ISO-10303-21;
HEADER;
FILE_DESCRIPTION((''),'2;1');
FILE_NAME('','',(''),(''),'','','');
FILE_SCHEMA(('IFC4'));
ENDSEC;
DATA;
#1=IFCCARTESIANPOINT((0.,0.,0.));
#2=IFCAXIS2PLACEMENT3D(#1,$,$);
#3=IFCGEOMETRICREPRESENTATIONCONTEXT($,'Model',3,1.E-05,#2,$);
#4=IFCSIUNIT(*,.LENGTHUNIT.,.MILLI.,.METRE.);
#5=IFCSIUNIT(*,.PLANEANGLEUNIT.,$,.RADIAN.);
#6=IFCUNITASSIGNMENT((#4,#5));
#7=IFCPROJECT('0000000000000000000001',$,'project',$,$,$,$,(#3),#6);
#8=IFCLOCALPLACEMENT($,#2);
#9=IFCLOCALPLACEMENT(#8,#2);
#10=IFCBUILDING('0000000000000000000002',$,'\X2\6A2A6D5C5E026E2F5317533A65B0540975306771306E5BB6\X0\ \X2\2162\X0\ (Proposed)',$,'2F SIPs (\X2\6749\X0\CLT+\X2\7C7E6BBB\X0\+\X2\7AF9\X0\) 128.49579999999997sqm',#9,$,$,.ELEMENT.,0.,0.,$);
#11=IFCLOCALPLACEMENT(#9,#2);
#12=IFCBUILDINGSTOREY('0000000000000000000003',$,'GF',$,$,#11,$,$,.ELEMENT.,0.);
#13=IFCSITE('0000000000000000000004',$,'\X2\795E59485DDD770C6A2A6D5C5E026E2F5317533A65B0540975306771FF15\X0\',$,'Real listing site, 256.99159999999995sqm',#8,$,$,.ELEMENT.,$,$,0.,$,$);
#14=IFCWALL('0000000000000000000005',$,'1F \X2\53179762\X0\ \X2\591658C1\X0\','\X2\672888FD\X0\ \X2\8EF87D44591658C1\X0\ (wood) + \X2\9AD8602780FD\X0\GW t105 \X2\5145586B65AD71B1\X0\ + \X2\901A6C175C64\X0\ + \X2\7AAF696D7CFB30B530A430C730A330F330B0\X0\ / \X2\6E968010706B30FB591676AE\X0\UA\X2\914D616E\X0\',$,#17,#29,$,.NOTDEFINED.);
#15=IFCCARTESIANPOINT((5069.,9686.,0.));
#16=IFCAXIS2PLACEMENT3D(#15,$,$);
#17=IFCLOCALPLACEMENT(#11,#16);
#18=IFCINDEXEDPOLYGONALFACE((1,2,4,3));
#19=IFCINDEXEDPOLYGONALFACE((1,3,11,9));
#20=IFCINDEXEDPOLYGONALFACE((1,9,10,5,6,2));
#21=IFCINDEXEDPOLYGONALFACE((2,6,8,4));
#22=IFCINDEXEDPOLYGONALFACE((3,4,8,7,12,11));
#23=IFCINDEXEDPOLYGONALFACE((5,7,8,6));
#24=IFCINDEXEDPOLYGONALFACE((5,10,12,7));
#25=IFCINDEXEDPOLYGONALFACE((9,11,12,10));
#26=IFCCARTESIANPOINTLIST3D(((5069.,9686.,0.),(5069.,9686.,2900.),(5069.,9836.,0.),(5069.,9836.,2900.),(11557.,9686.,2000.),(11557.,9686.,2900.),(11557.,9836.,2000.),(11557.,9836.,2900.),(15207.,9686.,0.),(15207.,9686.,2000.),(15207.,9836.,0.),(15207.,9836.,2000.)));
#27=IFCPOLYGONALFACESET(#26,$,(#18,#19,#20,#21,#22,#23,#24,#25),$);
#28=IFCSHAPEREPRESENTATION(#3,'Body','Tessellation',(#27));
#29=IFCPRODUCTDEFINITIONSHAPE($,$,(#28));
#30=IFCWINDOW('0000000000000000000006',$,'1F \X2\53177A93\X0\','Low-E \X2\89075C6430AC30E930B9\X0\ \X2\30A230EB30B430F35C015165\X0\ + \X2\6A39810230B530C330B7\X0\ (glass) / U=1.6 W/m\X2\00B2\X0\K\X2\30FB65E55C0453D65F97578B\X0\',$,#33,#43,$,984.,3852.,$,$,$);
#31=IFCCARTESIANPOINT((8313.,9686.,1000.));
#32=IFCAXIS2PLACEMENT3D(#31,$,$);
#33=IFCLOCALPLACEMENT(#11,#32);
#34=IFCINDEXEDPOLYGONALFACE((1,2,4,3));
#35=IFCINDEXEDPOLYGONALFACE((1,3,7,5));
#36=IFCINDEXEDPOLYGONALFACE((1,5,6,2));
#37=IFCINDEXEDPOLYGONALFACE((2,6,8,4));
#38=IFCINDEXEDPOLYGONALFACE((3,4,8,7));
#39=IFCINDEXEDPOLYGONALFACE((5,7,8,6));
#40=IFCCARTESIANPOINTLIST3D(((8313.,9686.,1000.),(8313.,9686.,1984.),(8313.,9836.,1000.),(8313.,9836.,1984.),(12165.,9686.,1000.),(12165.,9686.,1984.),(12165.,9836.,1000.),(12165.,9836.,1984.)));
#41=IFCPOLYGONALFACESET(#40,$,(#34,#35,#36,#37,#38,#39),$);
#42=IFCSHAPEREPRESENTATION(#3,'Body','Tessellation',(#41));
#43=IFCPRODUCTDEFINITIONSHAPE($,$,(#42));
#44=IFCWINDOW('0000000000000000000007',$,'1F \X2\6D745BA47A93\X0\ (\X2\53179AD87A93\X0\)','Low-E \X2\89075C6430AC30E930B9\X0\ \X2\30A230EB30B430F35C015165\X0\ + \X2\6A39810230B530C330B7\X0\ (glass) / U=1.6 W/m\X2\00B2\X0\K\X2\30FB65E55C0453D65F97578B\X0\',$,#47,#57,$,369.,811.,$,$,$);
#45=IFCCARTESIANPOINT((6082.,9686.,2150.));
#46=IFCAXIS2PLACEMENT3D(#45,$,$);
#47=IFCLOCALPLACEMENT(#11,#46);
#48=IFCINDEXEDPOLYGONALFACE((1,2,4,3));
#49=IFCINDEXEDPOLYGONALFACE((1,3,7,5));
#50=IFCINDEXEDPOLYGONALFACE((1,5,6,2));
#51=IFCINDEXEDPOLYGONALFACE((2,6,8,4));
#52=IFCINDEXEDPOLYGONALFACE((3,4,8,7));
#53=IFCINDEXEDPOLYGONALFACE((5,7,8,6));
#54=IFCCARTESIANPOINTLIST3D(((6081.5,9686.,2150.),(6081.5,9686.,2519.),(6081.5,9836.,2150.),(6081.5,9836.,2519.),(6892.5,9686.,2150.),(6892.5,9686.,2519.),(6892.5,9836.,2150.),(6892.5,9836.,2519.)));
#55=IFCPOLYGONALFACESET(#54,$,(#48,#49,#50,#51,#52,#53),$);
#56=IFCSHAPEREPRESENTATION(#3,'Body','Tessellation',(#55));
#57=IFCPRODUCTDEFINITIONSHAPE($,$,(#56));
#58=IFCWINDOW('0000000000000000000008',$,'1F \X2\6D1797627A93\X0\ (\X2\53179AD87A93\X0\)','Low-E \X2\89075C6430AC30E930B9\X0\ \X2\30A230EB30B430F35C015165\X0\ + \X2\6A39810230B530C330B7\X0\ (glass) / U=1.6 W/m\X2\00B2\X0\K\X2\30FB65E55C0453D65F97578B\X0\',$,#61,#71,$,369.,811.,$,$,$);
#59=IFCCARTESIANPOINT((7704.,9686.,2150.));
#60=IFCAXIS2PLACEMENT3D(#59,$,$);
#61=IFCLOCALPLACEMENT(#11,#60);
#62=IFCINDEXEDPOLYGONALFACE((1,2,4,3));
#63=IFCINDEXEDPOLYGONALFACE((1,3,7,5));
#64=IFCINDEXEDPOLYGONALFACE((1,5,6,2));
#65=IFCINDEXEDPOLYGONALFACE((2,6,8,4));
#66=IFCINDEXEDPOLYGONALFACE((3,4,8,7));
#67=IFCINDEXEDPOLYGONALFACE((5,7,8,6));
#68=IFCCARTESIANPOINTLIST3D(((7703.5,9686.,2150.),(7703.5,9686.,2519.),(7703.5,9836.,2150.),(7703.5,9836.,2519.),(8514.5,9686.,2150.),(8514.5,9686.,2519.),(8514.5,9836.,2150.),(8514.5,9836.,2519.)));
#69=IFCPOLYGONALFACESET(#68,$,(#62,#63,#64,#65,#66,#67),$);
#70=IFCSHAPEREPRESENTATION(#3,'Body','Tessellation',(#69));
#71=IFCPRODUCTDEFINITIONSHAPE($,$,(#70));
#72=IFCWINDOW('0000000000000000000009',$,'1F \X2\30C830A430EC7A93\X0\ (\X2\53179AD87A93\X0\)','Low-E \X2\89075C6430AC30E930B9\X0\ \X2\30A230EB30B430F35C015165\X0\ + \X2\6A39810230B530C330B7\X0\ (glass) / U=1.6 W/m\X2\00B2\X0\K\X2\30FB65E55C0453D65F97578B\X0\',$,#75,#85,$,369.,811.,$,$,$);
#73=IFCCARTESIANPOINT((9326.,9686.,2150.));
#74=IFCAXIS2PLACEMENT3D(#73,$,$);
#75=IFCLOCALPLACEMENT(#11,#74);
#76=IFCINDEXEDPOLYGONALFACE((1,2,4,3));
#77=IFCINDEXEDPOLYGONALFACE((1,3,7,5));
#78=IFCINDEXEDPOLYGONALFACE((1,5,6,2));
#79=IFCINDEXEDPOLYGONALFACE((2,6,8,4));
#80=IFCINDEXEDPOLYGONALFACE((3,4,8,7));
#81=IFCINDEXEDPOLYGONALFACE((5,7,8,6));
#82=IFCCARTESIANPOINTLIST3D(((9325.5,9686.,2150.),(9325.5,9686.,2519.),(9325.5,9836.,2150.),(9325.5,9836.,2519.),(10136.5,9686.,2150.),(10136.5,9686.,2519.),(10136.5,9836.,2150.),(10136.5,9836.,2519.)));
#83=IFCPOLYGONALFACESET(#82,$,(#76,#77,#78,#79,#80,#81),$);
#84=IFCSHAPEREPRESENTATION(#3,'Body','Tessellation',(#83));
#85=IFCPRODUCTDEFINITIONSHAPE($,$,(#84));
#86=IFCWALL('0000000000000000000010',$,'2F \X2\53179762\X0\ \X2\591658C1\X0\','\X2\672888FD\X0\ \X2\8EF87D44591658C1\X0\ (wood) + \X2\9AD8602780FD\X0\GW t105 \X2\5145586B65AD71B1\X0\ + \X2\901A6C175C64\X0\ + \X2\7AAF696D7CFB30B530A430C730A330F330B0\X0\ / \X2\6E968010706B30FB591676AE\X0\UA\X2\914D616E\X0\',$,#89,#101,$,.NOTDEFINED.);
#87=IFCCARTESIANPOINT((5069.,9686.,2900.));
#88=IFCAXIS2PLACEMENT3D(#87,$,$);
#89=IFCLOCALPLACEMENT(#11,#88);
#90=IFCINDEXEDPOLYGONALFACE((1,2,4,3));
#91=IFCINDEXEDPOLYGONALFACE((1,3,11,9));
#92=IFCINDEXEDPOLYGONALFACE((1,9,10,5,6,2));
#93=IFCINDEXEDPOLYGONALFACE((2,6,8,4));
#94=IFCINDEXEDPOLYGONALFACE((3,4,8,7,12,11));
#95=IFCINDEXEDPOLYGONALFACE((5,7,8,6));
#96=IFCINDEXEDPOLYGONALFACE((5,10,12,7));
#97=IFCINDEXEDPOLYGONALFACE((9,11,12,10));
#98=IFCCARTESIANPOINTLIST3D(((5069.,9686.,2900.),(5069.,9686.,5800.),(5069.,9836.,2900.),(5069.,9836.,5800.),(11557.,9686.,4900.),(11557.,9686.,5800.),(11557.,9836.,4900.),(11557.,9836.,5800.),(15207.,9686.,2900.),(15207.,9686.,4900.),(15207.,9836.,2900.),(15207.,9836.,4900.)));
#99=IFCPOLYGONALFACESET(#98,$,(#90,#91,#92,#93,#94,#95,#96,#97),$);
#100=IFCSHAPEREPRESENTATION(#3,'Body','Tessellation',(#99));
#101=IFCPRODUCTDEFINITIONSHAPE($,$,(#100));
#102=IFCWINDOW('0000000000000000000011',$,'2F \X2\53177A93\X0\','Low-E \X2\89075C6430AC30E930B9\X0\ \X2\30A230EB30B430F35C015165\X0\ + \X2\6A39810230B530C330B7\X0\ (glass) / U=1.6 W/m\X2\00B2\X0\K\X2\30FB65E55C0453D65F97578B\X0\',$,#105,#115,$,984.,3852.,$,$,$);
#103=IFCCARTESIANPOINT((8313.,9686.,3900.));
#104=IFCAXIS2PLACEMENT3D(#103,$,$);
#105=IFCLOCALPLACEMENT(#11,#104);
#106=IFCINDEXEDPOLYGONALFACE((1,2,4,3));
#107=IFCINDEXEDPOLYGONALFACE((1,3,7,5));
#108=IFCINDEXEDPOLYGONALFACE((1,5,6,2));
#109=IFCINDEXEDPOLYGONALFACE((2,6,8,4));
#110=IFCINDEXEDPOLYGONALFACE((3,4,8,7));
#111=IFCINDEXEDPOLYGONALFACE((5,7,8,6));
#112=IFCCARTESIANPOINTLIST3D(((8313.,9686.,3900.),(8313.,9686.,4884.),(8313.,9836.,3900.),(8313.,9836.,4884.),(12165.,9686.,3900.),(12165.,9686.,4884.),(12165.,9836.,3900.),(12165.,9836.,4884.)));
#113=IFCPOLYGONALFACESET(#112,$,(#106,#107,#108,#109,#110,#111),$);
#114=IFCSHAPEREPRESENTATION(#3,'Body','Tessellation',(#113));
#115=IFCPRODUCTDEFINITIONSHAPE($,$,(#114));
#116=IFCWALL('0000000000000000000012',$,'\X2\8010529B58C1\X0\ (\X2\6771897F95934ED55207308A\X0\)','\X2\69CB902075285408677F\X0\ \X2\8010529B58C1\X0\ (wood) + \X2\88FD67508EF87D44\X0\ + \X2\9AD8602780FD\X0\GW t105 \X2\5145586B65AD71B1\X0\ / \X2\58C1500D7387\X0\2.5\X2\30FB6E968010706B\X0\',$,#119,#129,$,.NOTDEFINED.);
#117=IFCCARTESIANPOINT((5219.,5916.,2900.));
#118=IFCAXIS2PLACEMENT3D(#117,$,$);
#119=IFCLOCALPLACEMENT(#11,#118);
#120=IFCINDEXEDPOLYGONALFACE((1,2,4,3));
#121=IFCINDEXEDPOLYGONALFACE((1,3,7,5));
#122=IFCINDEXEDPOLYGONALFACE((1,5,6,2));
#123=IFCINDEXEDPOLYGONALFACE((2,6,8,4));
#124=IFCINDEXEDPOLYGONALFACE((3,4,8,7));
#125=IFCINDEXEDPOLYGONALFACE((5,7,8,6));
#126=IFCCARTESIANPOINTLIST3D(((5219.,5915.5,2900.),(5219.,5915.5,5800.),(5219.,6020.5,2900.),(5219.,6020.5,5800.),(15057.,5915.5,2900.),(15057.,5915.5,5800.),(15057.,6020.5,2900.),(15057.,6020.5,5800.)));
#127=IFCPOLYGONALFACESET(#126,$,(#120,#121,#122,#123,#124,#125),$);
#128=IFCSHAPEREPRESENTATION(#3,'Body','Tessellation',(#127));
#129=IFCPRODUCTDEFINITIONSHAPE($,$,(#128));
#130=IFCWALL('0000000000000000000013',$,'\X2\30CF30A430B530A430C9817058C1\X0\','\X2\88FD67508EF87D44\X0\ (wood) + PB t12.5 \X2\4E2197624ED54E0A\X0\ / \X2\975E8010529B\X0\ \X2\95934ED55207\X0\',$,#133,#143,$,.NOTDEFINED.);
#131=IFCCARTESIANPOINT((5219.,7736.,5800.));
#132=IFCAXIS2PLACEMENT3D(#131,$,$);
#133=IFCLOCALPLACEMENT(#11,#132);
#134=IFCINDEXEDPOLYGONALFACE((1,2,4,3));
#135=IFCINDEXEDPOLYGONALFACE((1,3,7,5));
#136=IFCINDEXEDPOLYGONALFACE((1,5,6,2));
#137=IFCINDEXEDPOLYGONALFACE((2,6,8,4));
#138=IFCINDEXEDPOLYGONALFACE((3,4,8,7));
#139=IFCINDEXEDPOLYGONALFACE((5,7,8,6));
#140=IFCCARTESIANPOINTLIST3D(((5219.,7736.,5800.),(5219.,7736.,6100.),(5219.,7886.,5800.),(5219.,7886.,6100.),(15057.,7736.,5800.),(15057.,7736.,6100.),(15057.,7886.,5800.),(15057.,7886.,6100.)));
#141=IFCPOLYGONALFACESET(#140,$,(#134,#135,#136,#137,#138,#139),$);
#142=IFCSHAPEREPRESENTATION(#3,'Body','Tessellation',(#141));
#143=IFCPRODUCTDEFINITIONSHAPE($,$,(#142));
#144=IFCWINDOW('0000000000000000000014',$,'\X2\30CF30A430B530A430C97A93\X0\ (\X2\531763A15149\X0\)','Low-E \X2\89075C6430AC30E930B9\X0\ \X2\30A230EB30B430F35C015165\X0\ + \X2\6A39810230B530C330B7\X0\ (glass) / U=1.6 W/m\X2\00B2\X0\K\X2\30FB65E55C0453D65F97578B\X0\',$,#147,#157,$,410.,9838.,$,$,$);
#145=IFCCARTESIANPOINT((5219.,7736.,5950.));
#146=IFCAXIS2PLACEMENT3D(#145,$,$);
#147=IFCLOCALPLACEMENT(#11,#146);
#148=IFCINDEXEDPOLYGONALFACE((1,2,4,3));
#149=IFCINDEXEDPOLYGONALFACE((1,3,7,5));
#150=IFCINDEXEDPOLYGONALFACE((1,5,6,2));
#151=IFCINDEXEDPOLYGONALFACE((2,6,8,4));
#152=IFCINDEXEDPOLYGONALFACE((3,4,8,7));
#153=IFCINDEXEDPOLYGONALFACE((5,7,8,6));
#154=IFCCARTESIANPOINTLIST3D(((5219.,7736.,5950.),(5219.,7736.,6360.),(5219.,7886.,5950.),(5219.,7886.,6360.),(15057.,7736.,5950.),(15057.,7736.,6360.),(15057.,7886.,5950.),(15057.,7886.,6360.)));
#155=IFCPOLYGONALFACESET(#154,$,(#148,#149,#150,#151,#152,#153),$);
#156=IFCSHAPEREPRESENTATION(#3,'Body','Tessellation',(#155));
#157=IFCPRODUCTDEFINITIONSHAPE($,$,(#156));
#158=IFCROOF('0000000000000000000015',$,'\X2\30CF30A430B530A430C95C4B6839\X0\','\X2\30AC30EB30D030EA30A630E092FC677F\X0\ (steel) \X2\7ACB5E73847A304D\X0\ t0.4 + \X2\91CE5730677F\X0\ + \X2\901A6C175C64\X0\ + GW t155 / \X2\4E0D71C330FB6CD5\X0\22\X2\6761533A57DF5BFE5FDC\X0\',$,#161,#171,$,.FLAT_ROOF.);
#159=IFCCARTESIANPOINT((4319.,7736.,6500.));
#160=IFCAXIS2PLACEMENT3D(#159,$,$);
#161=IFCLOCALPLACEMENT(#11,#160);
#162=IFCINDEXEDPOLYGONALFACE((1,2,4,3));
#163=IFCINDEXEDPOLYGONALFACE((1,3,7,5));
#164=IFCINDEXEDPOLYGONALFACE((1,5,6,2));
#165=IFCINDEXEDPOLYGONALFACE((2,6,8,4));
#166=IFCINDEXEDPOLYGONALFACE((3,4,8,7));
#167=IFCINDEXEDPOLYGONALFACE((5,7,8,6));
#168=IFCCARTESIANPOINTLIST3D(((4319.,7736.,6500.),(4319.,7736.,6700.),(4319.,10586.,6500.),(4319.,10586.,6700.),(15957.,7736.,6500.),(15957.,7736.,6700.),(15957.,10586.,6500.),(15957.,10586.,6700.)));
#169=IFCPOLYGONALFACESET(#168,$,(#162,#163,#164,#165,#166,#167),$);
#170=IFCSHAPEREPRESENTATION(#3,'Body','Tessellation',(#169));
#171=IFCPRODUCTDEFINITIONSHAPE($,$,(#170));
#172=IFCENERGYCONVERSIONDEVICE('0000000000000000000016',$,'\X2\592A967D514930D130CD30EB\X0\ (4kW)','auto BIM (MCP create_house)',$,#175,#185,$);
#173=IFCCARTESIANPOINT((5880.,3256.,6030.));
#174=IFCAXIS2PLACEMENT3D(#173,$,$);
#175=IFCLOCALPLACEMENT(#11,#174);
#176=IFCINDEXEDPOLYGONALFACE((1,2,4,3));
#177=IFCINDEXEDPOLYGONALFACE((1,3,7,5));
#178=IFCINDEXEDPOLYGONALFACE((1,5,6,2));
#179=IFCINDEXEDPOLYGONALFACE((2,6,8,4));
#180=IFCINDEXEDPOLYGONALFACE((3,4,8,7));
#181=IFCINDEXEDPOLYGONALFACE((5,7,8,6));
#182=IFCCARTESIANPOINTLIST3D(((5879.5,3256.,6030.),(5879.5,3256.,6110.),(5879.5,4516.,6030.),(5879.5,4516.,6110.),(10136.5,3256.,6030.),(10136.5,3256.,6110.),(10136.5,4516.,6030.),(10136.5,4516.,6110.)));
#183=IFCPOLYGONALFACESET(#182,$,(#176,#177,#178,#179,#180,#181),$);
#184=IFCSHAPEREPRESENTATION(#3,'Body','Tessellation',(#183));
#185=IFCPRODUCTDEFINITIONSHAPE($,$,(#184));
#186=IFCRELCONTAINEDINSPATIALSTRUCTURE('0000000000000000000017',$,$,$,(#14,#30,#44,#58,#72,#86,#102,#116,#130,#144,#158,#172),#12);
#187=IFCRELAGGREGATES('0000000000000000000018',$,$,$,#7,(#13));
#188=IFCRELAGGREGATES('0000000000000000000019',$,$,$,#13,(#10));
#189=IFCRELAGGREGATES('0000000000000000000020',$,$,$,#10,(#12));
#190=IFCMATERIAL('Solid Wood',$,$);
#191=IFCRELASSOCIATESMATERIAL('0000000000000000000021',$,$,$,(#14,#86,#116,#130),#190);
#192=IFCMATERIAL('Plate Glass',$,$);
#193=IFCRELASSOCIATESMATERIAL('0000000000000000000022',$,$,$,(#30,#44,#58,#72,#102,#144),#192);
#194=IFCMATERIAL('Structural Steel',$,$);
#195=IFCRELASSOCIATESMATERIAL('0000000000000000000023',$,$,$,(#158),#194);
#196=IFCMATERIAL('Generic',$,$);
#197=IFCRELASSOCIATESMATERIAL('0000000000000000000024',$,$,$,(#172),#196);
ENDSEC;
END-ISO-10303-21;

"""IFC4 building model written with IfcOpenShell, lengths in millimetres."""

from ifc_helpers import new_model, si_unit, frame, frame_2d, origin, place, context, project, spatial, rectangle, extrude, material, element, fill, save


model = new_model("IFC4")

# Units and contexts
model_context = context("Model", 3, precision=1e-05, world=origin())
ifc_project = project(units=[si_unit("LENGTHUNIT", "METRE", prefix="MILLI"), si_unit("PLANEANGLEUNIT", "RADIAN")], contexts=[model_context])

# Site, building, storey
site_placement = place(None, origin())
site = spatial("IfcSite", under=ifc_project, at=site_placement, Name="神奈川県横浜市港北区新吉田東５", ObjectType="Real listing site, 256.99159999999995sqm", CompositionType="ELEMENT", RefElevation=0.0)
building_placement = place(site_placement, origin())
building = spatial("IfcBuilding", under=site, at=building_placement, Name="横浜市港北区新吉田東の家 Ⅲ (Proposed)", ObjectType="2F SIPs (杉CLT+籾殻+竹) 128.49579999999997sqm", CompositionType="ELEMENT", ElevationOfRefHeight=0.0, ElevationOfTerrain=0.0)
storey_placement = place(building_placement, origin())
storey = spatial("IfcBuildingStorey", under=building, at=storey_placement, Name="GF", CompositionType="ELEMENT", Elevation=0.0)

# Wall, openings, windows
ifc_material_1 = material(Name="Solid Wood")
wall_1_placement = place(storey_placement, frame((5069.0, 9686.0, 0.0)))
wall_1 = element("IfcWall", 1, at=wall_1_placement, inside=storey, material=ifc_material_1, Name="1F 北面 外壁", Description="木製 軸組外壁 (wood) + 高性能GW t105 充填断熱 + 通気層 + 窯業系サイディング / 準耐火・外皮UA配慮", PredefinedType="NOTDEFINED", context=model_context, shape_type="SweptSolid", body=[
    extrude(rectangle(XDim=10138.0, YDim=150.0, at=frame_2d((5069.0, 75.0))), frame((5069.0, 9686.0, 0.0)), (0.0, 0.0, 1.0), 2900.0),
])
opening_1_placement = place(storey_placement, frame((8313.0, 9686.0, 1000.0)))
opening_1 = element("IfcOpeningElement", 2, at=opening_1_placement, cuts=wall_1, PredefinedType="NOTDEFINED", context=model_context, shape_type="SweptSolid", body=[
    extrude(rectangle(XDim=3852.0, YDim=150.0, at=frame_2d((1926.0, 75.0))), frame((8313.0, 9686.0, 1000.0)), (0.0, 0.0, 1.0), 984.0),
])
opening_2_placement = place(storey_placement, frame((6082.0, 9686.0, 2150.0)))
opening_2 = element("IfcOpeningElement", 3, at=opening_2_placement, cuts=wall_1, PredefinedType="NOTDEFINED", context=model_context, shape_type="SweptSolid", body=[
    extrude(rectangle(XDim=811.0, YDim=150.0, at=frame_2d((405.0, 75.0))), frame((6082.0, 9686.0, 2150.0)), (0.0, 0.0, 1.0), 369.0),
])
opening_3_placement = place(storey_placement, frame((7704.0, 9686.0, 2150.0)))
opening_3 = element("IfcOpeningElement", 4, at=opening_3_placement, cuts=wall_1, PredefinedType="NOTDEFINED", context=model_context, shape_type="SweptSolid", body=[
    extrude(rectangle(XDim=811.0, YDim=150.0, at=frame_2d((405.0, 75.0))), frame((7704.0, 9686.0, 2150.0)), (0.0, 0.0, 1.0), 369.0),
])
opening_4_placement = place(storey_placement, frame((9326.0, 9686.0, 2150.0)))
opening_4 = element("IfcOpeningElement", 5, at=opening_4_placement, cuts=wall_1, PredefinedType="NOTDEFINED", context=model_context, shape_type="SweptSolid", body=[
    extrude(rectangle(XDim=811.0, YDim=150.0, at=frame_2d((405.0, 75.0))), frame((9326.0, 9686.0, 2150.0)), (0.0, 0.0, 1.0), 369.0),
])
ifc_material_2 = material(Name="Plate Glass")
window_1_placement = place(storey_placement, frame((8313.0, 9686.0, 1000.0)))
window_1 = element("IfcWindow", 6, at=window_1_placement, inside=storey, material=ifc_material_2, Name="1F 北窓", Description="Low-E 複層ガラス アルゴン封入 + 樹脂サッシ (glass) / U=1.6 W/m²K・日射取得型", OverallHeight=984.0, OverallWidth=3852.0, context=model_context, shape_type="SweptSolid", body=[
    extrude(rectangle(XDim=3852.0, YDim=150.0, at=frame_2d((1926.0, 75.0))), frame((8313.0, 9686.0, 1000.0)), (0.0, 0.0, 1.0), 984.0),
])
fill(opening_1, window_1)
window_2_placement = place(storey_placement, frame((6082.0, 9686.0, 2150.0)))
window_2 = element("IfcWindow", 7, at=window_2_placement, inside=storey, material=ifc_material_2, Name="1F 浴室窓 (北高窓)", Description="Low-E 複層ガラス アルゴン封入 + 樹脂サッシ (glass) / U=1.6 W/m²K・日射取得型", OverallHeight=369.0, OverallWidth=811.0, context=model_context, shape_type="SweptSolid", body=[
    extrude(rectangle(XDim=811.0, YDim=150.0, at=frame_2d((405.0, 75.0))), frame((6082.0, 9686.0, 2150.0)), (0.0, 0.0, 1.0), 369.0),
])
fill(opening_2, window_2)
window_3_placement = place(storey_placement, frame((7704.0, 9686.0, 2150.0)))
window_3 = element("IfcWindow", 8, at=window_3_placement, inside=storey, material=ifc_material_2, Name="1F 洗面窓 (北高窓)", Description="Low-E 複層ガラス アルゴン封入 + 樹脂サッシ (glass) / U=1.6 W/m²K・日射取得型", OverallHeight=369.0, OverallWidth=811.0, context=model_context, shape_type="SweptSolid", body=[
    extrude(rectangle(XDim=811.0, YDim=150.0, at=frame_2d((405.0, 75.0))), frame((7704.0, 9686.0, 2150.0)), (0.0, 0.0, 1.0), 369.0),
])
fill(opening_3, window_3)
window_4_placement = place(storey_placement, frame((9326.0, 9686.0, 2150.0)))
window_4 = element("IfcWindow", 9, at=window_4_placement, inside=storey, material=ifc_material_2, Name="1F トイレ窓 (北高窓)", Description="Low-E 複層ガラス アルゴン封入 + 樹脂サッシ (glass) / U=1.6 W/m²K・日射取得型", OverallHeight=369.0, OverallWidth=811.0, context=model_context, shape_type="SweptSolid", body=[
    extrude(rectangle(XDim=811.0, YDim=150.0, at=frame_2d((405.0, 75.0))), frame((9326.0, 9686.0, 2150.0)), (0.0, 0.0, 1.0), 369.0),
])
fill(opening_4, window_4)

# Wall, opening, window
wall_2_placement = place(storey_placement, frame((5069.0, 9686.0, 2900.0)))
wall_2 = element("IfcWall", 10, at=wall_2_placement, inside=storey, material=ifc_material_1, Name="2F 北面 外壁", Description="木製 軸組外壁 (wood) + 高性能GW t105 充填断熱 + 通気層 + 窯業系サイディング / 準耐火・外皮UA配慮", PredefinedType="NOTDEFINED", context=model_context, shape_type="SweptSolid", body=[
    extrude(rectangle(XDim=10138.0, YDim=150.0, at=frame_2d((5069.0, 75.0))), frame((5069.0, 9686.0, 2900.0)), (0.0, 0.0, 1.0), 2900.0),
])
opening_5_placement = place(storey_placement, frame((8313.0, 9686.0, 3900.0)))
opening_5 = element("IfcOpeningElement", 11, at=opening_5_placement, cuts=wall_2, PredefinedType="NOTDEFINED", context=model_context, shape_type="SweptSolid", body=[
    extrude(rectangle(XDim=3852.0, YDim=150.0, at=frame_2d((1926.0, 75.0))), frame((8313.0, 9686.0, 3900.0)), (0.0, 0.0, 1.0), 984.0),
])
window_5_placement = place(storey_placement, frame((8313.0, 9686.0, 3900.0)))
window_5 = element("IfcWindow", 12, at=window_5_placement, inside=storey, material=ifc_material_2, Name="2F 北窓", Description="Low-E 複層ガラス アルゴン封入 + 樹脂サッシ (glass) / U=1.6 W/m²K・日射取得型", OverallHeight=984.0, OverallWidth=3852.0, context=model_context, shape_type="SweptSolid", body=[
    extrude(rectangle(XDim=3852.0, YDim=150.0, at=frame_2d((1926.0, 75.0))), frame((8313.0, 9686.0, 3900.0)), (0.0, 0.0, 1.0), 984.0),
])
fill(opening_5, window_5)

# Wall
wall_3_placement = place(storey_placement, frame((5219.0, 5916.0, 2900.0)))
element("IfcWall", 13, at=wall_3_placement, inside=storey, material=ifc_material_1, Name="耐力壁 (東西間仕切り)", Description="構造用合板 耐力壁 (wood) + 製材軸組 + 高性能GW t105 充填断熱 / 壁倍率2.5・準耐火", PredefinedType="NOTDEFINED", context=model_context, shape_type="SweptSolid", body=[
    extrude(rectangle(XDim=9838.0, YDim=105.0, at=frame_2d((4919.0, 52.0))), frame((5219.0, 5916.0, 2900.0)), (0.0, 0.0, 1.0), 2900.0),
])

# Wall, opening, window
wall_4_placement = place(storey_placement, frame((5219.0, 7736.0, 5800.0)))
wall_4 = element("IfcWall", 14, at=wall_4_placement, inside=storey, material=ifc_material_1, Name="ハイサイド腰壁", Description="製材軸組 (wood) + PB t12.5 両面仕上 / 非耐力 間仕切", PredefinedType="NOTDEFINED", context=model_context, shape_type="SweptSolid", body=[
    extrude(rectangle(XDim=9838.0, YDim=150.0, at=frame_2d((4919.0, 75.0))), frame((5219.0, 7736.0, 5800.0)), (0.0, 0.0, 1.0), 700.0),
])
opening_6_placement = place(storey_placement, frame((5219.0, 7736.0, 5950.0)))
opening_6 = element("IfcOpeningElement", 15, at=opening_6_placement, cuts=wall_4, PredefinedType="NOTDEFINED", context=model_context, shape_type="SweptSolid", body=[
    extrude(rectangle(XDim=9838.0, YDim=150.0, at=frame_2d((4919.0, 75.0))), frame((5219.0, 7736.0, 5950.0)), (0.0, 0.0, 1.0), 410.0),
])
window_6_placement = place(storey_placement, frame((5219.0, 7736.0, 5950.0)))
window_6 = element("IfcWindow", 16, at=window_6_placement, inside=storey, material=ifc_material_2, Name="ハイサイド窓 (北採光)", Description="Low-E 複層ガラス アルゴン封入 + 樹脂サッシ (glass) / U=1.6 W/m²K・日射取得型", OverallHeight=410.0, OverallWidth=9838.0, context=model_context, shape_type="SweptSolid", body=[
    extrude(rectangle(XDim=9838.0, YDim=150.0, at=frame_2d((4919.0, 75.0))), frame((5219.0, 7736.0, 5950.0)), (0.0, 0.0, 1.0), 410.0),
])
fill(opening_6, window_6)

# Roof
ifc_material_3 = material(Name="Structural Steel")
roof_placement = place(storey_placement, frame((4319.0, 7736.0, 6500.0)))
element("IfcRoof", 17, at=roof_placement, inside=storey, material=ifc_material_3, Name="ハイサイド屋根", Description="ガルバリウム鋼板 (steel) 立平葺き t0.4 + 野地板 + 通気層 + GW t155 / 不燃・法22条区域対応", PredefinedType="FLAT_ROOF", context=model_context, shape_type="SweptSolid", body=[
    extrude(rectangle(XDim=11638.0, YDim=2850.0, at=frame_2d((5819.0, 1425.0))), frame((4319.0, 7736.0, 6500.0)), (0.0, 0.0, 1.0), 200.0),
])

# Energy conversion device
ifc_material_4 = material(Name="Generic")
energy_conversion_device_placement = place(storey_placement, frame((5880.0, 3256.0, 6030.0)))
element("IfcEnergyConversionDevice", 18, at=energy_conversion_device_placement, inside=storey, material=ifc_material_4, Name="太陽光パネル (4kW)", Description="auto BIM (MCP create_house)", context=model_context, shape_type="SweptSolid", body=[
    extrude(rectangle(XDim=4257.0, YDim=1260.0, at=frame_2d((2128.0, 630.0))), frame((5880.0, 3256.0, 6030.0)), (0.0, 0.0, 1.0), 80.0),
])

save(model, "model.ifc")
